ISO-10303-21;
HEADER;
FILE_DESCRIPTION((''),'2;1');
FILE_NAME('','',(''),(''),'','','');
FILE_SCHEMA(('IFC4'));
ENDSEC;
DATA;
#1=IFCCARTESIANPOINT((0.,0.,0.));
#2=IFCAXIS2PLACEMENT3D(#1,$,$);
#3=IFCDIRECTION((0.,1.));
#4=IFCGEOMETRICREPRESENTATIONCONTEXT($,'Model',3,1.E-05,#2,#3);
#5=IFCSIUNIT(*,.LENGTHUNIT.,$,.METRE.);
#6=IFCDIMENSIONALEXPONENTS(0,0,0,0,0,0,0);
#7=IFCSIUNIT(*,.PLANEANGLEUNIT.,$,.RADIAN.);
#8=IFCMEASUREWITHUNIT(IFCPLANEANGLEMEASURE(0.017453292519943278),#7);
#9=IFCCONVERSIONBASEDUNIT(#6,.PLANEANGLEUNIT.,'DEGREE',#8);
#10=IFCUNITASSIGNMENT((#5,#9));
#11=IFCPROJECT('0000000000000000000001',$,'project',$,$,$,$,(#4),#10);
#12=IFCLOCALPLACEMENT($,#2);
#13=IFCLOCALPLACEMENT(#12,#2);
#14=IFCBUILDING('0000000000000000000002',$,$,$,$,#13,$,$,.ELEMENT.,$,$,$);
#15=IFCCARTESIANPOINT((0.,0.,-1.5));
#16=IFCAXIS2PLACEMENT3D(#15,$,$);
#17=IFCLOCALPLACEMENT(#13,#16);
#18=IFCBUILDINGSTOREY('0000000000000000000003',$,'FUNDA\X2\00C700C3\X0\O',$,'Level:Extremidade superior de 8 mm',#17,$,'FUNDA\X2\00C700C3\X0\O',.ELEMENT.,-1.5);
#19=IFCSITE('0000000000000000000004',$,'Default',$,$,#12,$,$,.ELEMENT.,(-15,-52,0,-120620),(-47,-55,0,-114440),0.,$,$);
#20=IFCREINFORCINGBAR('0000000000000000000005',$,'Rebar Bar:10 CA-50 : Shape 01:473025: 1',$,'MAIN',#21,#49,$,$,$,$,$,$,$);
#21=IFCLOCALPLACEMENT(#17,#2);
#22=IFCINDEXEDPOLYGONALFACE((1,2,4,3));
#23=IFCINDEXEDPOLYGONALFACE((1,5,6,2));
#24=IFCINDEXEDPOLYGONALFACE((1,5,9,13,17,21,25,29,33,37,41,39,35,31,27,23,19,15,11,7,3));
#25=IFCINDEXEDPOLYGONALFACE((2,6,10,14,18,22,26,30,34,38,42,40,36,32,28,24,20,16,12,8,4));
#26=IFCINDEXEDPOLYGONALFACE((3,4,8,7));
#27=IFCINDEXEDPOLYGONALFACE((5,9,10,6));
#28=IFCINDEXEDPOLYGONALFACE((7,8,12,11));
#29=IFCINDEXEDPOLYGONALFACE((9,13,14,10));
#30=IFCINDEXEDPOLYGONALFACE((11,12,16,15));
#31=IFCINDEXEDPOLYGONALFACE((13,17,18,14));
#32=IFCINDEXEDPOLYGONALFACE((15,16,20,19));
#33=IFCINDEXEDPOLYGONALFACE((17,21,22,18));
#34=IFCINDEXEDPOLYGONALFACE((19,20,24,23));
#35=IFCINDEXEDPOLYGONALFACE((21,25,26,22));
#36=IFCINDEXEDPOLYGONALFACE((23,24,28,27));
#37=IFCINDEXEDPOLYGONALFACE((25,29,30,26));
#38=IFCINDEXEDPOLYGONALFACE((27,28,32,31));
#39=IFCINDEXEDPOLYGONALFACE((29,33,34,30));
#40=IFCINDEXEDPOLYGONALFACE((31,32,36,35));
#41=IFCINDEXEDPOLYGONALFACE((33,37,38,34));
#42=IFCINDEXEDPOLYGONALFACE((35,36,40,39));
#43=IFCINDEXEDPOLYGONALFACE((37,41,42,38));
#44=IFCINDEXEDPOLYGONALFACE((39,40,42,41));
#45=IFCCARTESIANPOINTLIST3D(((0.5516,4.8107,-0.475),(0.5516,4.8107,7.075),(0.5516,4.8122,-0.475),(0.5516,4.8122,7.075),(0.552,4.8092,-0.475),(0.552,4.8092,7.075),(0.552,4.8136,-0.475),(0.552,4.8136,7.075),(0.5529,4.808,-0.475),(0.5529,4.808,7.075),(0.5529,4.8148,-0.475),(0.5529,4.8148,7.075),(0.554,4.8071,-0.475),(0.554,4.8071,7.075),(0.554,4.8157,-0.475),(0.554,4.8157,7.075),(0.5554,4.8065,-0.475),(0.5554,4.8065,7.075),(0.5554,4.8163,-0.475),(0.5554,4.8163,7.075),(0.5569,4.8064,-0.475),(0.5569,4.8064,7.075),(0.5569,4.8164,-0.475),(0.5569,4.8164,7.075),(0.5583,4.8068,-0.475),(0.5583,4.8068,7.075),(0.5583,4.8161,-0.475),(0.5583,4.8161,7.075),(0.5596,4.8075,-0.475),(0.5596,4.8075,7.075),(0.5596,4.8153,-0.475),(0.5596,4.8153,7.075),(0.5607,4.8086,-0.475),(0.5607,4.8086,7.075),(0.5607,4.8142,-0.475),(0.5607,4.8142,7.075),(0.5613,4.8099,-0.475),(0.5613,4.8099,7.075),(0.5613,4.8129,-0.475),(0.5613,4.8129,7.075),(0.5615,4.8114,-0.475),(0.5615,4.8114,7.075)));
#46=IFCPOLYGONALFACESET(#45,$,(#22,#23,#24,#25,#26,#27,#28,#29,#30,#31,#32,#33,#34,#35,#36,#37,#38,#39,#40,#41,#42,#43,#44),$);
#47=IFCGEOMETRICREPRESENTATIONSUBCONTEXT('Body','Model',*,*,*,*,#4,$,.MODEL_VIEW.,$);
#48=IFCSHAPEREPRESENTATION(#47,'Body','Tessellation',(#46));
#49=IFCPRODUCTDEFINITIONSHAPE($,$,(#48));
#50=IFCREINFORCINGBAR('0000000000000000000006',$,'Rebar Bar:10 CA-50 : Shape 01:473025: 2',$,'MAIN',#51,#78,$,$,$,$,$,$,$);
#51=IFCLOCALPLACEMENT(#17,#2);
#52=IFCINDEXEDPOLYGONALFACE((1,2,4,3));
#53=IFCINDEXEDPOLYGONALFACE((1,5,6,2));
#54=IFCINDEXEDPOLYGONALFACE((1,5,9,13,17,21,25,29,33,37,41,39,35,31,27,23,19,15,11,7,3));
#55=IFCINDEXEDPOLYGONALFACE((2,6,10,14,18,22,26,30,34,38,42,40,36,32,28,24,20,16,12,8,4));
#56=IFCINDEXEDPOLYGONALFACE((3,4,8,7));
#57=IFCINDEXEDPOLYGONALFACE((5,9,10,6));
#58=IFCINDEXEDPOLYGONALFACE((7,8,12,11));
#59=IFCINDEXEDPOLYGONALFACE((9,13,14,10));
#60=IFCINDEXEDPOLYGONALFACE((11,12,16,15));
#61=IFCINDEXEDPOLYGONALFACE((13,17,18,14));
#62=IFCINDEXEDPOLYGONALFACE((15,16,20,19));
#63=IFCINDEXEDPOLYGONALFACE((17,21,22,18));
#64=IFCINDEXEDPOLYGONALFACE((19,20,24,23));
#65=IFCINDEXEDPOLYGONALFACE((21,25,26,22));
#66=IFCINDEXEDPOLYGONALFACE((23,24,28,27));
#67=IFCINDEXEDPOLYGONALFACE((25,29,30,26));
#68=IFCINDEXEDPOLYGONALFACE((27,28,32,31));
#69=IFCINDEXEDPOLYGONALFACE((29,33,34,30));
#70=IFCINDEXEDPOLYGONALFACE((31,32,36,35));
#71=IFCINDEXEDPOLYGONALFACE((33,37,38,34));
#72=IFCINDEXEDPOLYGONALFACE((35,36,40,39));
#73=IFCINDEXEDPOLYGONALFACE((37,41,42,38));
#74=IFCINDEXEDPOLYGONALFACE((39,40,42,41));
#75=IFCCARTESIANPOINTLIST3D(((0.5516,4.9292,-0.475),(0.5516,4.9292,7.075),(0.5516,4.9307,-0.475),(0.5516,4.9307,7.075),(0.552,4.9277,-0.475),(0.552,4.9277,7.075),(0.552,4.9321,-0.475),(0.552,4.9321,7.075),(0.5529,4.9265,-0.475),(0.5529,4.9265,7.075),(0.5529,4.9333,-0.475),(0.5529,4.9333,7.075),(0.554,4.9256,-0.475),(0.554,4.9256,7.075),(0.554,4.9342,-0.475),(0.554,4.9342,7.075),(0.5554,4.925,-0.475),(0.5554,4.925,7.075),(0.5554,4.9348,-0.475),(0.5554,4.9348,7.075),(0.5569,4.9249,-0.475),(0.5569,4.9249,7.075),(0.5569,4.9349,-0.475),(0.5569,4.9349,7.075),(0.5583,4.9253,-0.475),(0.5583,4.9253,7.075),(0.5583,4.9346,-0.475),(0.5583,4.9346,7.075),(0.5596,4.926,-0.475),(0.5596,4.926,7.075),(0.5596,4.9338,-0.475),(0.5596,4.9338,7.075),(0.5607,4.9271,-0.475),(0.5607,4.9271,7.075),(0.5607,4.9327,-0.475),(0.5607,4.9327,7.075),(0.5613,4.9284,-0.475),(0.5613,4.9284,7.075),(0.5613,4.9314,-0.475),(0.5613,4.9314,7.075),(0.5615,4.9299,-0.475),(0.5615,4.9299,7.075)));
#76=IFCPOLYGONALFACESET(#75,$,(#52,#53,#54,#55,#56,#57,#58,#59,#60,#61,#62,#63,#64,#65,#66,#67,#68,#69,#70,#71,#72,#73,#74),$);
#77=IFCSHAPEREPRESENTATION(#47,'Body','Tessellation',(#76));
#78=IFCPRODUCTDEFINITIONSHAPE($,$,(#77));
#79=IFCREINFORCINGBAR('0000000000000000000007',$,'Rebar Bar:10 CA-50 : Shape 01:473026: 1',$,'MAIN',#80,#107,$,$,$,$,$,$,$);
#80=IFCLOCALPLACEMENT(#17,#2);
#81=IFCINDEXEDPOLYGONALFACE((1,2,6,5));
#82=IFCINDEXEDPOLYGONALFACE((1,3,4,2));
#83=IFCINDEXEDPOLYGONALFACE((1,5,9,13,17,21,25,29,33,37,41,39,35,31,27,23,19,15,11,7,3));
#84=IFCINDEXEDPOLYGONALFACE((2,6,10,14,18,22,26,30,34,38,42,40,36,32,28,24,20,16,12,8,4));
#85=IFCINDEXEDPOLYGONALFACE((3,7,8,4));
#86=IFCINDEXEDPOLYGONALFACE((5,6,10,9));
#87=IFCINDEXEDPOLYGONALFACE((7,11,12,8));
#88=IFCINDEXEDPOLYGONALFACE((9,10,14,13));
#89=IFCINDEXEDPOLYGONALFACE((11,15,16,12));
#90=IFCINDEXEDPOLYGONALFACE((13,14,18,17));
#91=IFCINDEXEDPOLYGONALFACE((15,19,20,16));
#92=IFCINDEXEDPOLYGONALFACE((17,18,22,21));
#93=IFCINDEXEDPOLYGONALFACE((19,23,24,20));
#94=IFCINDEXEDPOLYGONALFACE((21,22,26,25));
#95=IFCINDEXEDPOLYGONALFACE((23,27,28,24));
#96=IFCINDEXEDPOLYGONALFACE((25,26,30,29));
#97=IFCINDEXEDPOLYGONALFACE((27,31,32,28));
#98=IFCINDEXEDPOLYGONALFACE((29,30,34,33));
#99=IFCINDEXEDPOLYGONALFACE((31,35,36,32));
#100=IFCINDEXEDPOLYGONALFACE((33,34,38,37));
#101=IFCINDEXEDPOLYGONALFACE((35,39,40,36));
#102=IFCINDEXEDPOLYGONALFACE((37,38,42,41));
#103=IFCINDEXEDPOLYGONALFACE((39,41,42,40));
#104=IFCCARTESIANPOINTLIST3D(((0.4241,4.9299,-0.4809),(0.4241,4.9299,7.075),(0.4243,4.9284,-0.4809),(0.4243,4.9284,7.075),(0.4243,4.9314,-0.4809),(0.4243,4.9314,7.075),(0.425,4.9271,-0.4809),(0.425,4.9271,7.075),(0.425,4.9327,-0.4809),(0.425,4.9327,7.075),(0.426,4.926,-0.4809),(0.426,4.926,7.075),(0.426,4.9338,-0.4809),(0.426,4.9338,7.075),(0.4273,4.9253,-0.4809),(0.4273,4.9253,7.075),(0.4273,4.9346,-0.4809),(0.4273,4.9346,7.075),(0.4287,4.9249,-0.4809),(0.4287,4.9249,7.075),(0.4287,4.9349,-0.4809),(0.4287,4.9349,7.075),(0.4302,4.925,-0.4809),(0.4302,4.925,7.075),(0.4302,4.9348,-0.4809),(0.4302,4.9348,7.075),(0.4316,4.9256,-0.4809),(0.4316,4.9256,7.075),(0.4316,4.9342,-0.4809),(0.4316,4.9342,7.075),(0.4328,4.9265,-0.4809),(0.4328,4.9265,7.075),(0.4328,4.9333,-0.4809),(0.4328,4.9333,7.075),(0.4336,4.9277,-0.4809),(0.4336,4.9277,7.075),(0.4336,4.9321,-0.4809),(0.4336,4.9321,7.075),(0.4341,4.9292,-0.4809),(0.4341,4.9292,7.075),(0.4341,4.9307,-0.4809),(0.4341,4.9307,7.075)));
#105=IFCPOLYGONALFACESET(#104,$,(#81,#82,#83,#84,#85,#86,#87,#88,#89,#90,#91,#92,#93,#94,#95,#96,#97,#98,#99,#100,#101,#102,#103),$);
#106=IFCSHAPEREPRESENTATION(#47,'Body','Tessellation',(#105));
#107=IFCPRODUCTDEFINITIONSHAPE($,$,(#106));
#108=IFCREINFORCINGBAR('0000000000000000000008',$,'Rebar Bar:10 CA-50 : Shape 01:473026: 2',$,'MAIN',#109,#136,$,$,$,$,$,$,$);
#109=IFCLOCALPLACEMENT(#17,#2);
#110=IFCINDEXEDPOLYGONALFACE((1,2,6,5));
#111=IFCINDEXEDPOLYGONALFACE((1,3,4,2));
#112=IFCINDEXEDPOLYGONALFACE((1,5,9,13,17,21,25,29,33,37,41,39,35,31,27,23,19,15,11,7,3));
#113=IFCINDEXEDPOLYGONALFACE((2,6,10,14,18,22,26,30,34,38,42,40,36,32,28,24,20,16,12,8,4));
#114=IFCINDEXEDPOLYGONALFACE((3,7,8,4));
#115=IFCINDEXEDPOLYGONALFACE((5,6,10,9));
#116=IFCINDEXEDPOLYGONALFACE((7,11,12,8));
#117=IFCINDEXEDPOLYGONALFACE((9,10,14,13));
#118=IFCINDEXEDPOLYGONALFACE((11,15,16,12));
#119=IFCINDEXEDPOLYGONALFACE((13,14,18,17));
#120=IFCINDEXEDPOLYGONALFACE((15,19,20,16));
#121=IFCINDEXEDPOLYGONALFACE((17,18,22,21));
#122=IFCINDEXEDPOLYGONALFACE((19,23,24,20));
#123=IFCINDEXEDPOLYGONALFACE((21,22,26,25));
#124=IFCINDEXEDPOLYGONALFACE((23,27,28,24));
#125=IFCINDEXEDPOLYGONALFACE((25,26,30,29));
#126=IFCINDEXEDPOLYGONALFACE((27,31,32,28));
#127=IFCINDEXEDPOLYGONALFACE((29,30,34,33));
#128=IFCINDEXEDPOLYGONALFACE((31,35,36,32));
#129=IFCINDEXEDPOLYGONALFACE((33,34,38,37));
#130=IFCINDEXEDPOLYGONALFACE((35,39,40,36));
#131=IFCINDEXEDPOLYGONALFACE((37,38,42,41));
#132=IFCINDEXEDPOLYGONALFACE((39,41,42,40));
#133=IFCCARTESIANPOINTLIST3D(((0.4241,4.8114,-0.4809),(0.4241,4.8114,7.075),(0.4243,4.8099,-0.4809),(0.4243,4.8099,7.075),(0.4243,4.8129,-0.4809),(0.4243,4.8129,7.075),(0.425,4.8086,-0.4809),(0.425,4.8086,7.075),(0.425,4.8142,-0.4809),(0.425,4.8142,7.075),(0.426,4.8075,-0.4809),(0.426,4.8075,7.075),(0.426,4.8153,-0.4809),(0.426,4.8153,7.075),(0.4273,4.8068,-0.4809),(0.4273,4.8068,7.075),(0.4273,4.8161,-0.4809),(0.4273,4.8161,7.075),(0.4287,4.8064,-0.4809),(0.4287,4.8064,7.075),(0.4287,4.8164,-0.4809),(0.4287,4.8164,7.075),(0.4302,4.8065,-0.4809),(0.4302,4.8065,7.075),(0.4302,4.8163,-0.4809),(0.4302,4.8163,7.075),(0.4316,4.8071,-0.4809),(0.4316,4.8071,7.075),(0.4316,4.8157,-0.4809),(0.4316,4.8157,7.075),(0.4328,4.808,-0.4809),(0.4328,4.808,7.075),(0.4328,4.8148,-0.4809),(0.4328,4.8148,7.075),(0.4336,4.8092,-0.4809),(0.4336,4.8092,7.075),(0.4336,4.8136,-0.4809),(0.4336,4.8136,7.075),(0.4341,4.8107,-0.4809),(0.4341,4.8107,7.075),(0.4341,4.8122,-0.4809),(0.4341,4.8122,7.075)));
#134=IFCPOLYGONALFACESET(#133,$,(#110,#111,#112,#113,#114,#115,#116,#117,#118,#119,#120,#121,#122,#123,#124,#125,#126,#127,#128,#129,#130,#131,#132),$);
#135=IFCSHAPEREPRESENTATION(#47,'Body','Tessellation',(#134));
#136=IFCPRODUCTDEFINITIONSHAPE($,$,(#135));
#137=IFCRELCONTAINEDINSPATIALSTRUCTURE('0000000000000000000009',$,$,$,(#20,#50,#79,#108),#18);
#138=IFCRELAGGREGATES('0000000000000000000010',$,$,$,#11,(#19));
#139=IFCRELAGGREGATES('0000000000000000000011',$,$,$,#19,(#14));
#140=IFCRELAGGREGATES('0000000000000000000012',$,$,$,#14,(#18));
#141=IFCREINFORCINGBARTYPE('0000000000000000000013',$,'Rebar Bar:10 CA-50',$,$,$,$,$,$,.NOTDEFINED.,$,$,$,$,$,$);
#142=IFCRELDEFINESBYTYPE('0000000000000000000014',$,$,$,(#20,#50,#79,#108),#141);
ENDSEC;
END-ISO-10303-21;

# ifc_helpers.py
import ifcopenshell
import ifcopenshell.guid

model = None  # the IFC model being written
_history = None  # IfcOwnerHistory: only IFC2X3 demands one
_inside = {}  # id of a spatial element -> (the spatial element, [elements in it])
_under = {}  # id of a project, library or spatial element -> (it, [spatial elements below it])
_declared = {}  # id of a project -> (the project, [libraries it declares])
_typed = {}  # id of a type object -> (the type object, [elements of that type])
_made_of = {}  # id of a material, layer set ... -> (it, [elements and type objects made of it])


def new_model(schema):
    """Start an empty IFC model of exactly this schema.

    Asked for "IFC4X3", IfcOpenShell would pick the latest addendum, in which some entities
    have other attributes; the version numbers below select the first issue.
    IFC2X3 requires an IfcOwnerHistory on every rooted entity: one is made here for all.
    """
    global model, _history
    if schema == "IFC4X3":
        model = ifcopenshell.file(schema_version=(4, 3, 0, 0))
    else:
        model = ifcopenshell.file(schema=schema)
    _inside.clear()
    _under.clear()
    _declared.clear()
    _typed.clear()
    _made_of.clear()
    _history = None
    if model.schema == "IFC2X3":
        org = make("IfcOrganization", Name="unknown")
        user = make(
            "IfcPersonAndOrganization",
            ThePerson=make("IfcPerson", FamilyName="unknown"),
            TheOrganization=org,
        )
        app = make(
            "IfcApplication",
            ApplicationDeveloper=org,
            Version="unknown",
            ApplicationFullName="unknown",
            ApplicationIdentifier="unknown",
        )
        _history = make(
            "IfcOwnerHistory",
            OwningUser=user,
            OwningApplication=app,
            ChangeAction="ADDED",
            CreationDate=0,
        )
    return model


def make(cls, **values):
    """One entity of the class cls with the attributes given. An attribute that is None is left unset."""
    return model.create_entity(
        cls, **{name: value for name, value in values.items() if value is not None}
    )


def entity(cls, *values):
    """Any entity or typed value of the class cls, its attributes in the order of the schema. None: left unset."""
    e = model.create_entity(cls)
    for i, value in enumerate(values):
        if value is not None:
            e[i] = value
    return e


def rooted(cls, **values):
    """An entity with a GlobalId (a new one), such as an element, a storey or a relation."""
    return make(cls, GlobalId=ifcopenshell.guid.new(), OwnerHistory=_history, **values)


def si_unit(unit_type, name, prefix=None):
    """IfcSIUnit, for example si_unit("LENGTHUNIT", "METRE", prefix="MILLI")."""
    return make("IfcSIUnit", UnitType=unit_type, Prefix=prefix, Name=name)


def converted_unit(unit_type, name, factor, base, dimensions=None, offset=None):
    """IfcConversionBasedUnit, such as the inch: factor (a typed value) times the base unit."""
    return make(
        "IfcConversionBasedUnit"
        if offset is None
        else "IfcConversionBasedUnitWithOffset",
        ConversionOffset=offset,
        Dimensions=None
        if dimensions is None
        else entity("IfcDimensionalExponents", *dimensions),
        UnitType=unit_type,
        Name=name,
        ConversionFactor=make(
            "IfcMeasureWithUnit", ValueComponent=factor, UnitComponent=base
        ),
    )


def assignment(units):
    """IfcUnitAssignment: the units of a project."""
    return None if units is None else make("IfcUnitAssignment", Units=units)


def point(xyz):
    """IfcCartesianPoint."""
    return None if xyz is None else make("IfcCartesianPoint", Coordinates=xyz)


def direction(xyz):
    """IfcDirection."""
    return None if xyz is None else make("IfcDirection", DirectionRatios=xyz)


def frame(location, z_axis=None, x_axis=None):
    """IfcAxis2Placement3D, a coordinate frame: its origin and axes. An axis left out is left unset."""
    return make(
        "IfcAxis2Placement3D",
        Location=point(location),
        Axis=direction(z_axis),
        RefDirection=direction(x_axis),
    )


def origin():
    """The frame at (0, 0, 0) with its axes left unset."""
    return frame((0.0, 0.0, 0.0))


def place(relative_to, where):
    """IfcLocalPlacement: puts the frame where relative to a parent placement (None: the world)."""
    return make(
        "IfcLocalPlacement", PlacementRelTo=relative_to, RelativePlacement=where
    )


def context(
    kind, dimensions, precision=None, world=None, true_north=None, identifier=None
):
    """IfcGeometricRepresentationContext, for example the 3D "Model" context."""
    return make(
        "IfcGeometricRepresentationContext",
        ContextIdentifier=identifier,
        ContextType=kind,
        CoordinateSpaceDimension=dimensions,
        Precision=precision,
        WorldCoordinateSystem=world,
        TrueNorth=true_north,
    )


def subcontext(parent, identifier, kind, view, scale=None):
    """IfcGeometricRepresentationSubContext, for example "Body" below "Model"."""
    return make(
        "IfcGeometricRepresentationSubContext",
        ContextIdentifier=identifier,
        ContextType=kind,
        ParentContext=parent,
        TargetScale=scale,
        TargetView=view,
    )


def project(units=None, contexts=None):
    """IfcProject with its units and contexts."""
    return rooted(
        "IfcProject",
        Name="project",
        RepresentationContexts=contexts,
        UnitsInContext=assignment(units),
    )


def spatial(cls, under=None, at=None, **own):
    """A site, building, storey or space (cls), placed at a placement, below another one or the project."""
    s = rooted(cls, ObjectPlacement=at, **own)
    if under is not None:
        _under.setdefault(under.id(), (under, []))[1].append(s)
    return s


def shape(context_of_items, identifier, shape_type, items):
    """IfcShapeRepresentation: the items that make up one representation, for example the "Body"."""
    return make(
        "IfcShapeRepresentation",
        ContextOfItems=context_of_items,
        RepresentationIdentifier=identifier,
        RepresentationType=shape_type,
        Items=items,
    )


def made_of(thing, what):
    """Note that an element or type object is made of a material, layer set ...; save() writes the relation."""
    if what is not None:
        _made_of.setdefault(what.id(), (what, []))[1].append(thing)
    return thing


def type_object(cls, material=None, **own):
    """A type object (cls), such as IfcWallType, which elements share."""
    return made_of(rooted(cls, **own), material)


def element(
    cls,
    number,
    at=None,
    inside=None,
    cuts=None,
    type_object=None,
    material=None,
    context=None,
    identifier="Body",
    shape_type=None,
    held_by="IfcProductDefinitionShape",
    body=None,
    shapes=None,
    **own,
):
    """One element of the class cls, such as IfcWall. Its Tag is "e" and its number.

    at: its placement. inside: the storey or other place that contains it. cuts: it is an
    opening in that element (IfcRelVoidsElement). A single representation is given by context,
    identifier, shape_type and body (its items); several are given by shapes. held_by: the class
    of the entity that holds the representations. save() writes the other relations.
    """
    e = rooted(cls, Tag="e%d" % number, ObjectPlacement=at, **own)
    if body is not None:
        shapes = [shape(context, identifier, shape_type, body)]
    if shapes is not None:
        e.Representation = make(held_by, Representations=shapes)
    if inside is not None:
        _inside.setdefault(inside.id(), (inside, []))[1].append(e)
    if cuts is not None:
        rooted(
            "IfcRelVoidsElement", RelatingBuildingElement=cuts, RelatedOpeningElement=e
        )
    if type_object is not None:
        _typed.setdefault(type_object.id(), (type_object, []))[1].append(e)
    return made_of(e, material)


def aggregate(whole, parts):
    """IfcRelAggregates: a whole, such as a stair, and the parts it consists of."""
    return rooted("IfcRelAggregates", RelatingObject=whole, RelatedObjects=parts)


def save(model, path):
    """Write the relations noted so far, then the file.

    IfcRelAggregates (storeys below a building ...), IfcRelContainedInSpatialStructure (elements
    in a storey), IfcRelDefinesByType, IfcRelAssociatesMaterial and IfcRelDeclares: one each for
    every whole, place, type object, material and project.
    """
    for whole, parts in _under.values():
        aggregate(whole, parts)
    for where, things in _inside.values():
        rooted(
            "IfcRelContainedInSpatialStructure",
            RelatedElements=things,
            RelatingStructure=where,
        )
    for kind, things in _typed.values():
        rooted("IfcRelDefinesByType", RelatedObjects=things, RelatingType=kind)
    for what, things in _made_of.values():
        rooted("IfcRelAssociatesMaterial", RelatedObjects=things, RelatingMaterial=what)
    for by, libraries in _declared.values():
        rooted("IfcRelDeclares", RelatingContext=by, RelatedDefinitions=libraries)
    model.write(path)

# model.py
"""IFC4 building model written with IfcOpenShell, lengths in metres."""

from ifc_helpers import new_model, entity, si_unit, converted_unit, direction, frame, origin, place, context, subcontext, project, spatial, type_object, element, save


model = new_model("IFC4")

# Units and contexts
model_context = context("Model", 3, precision=1e-05, world=origin(), true_north=direction((0.0, 1.0)))
body_context = subcontext(model_context, "Body", "Model", "MODEL_VIEW")
ifc_project = project(units=[si_unit("LENGTHUNIT", "METRE"), converted_unit("PLANEANGLEUNIT", "DEGREE", entity("IfcPlaneAngleMeasure", 0.017453292519943278), si_unit("PLANEANGLEUNIT", "RADIAN"), dimensions=[0, 0, 0, 0, 0, 0, 0])], contexts=[model_context])

# Site, building, storey
site_placement = place(None, origin())
site = spatial("IfcSite", under=ifc_project, at=site_placement, Name="Default", CompositionType="ELEMENT", RefLatitude=(-15, -52, 0, -120620), RefLongitude=(-47, -55, 0, -114440), RefElevation=0.0)
building_placement = place(site_placement, origin())
building = spatial("IfcBuilding", under=site, at=building_placement, CompositionType="ELEMENT")
storey_placement = place(building_placement, frame((0.0, 0.0, -1.5)))
storey = spatial("IfcBuildingStorey", under=building, at=storey_placement, Name="FUNDAÇÃO", ObjectType="Level:Extremidade superior de 8 mm", LongName="FUNDAÇÃO", CompositionType="ELEMENT", Elevation=-1.5)

# Reinforcing bars
reinforcing_bar_type_1 = type_object("IfcReinforcingBarType", Name="Rebar Bar:10 CA-50", PredefinedType="NOTDEFINED")
reinforcing_bar_1_placement = place(storey_placement, origin())
element("IfcReinforcingBar", 1, at=reinforcing_bar_1_placement, inside=storey, type_object=reinforcing_bar_type_1, Name="Rebar Bar:10 CA-50 : Shape 01:473025: 1", ObjectType="MAIN", context=body_context, shape_type="AdvancedSweptSolid", body=[
    entity("IfcSweptDiskSolid", entity("IfcIndexedPolyCurve", entity("IfcCartesianPointList3D", [[0.5565, 4.8114, -0.475], [0.5565, 4.8114, 7.075]]), None, False), 0.005, None, 0.0, 1.0),
])
reinforcing_bar_2_placement = place(storey_placement, origin())
element("IfcReinforcingBar", 2, at=reinforcing_bar_2_placement, inside=storey, type_object=reinforcing_bar_type_1, Name="Rebar Bar:10 CA-50 : Shape 01:473025: 2", ObjectType="MAIN", context=body_context, shape_type="AdvancedSweptSolid", body=[
    entity("IfcSweptDiskSolid", entity("IfcIndexedPolyCurve", entity("IfcCartesianPointList3D", [[0.5565, 4.9299, -0.475], [0.5565, 4.9299, 7.075]]), None, False), 0.005, None, 0.0, 1.0),
])
reinforcing_bar_3_placement = place(storey_placement, origin())
element("IfcReinforcingBar", 3, at=reinforcing_bar_3_placement, inside=storey, type_object=reinforcing_bar_type_1, Name="Rebar Bar:10 CA-50 : Shape 01:473026: 1", ObjectType="MAIN", context=body_context, shape_type="AdvancedSweptSolid", body=[
    entity("IfcSweptDiskSolid", entity("IfcIndexedPolyCurve", entity("IfcCartesianPointList3D", [[0.4291, 4.9299, 7.075], [0.4291, 4.9299, -0.4809]]), None, False), 0.005, None, 0.0, 1.0),
])
reinforcing_bar_4_placement = place(storey_placement, origin())
element("IfcReinforcingBar", 4, at=reinforcing_bar_4_placement, inside=storey, type_object=reinforcing_bar_type_1, Name="Rebar Bar:10 CA-50 : Shape 01:473026: 2", ObjectType="MAIN", context=body_context, shape_type="AdvancedSweptSolid", body=[
    entity("IfcSweptDiskSolid", entity("IfcIndexedPolyCurve", entity("IfcCartesianPointList3D", [[0.4291, 4.8114, 7.075], [0.4291, 4.8114, -0.4809]]), None, False), 0.005, None, 0.0, 1.0),
])

save(model, "model.ifc")
